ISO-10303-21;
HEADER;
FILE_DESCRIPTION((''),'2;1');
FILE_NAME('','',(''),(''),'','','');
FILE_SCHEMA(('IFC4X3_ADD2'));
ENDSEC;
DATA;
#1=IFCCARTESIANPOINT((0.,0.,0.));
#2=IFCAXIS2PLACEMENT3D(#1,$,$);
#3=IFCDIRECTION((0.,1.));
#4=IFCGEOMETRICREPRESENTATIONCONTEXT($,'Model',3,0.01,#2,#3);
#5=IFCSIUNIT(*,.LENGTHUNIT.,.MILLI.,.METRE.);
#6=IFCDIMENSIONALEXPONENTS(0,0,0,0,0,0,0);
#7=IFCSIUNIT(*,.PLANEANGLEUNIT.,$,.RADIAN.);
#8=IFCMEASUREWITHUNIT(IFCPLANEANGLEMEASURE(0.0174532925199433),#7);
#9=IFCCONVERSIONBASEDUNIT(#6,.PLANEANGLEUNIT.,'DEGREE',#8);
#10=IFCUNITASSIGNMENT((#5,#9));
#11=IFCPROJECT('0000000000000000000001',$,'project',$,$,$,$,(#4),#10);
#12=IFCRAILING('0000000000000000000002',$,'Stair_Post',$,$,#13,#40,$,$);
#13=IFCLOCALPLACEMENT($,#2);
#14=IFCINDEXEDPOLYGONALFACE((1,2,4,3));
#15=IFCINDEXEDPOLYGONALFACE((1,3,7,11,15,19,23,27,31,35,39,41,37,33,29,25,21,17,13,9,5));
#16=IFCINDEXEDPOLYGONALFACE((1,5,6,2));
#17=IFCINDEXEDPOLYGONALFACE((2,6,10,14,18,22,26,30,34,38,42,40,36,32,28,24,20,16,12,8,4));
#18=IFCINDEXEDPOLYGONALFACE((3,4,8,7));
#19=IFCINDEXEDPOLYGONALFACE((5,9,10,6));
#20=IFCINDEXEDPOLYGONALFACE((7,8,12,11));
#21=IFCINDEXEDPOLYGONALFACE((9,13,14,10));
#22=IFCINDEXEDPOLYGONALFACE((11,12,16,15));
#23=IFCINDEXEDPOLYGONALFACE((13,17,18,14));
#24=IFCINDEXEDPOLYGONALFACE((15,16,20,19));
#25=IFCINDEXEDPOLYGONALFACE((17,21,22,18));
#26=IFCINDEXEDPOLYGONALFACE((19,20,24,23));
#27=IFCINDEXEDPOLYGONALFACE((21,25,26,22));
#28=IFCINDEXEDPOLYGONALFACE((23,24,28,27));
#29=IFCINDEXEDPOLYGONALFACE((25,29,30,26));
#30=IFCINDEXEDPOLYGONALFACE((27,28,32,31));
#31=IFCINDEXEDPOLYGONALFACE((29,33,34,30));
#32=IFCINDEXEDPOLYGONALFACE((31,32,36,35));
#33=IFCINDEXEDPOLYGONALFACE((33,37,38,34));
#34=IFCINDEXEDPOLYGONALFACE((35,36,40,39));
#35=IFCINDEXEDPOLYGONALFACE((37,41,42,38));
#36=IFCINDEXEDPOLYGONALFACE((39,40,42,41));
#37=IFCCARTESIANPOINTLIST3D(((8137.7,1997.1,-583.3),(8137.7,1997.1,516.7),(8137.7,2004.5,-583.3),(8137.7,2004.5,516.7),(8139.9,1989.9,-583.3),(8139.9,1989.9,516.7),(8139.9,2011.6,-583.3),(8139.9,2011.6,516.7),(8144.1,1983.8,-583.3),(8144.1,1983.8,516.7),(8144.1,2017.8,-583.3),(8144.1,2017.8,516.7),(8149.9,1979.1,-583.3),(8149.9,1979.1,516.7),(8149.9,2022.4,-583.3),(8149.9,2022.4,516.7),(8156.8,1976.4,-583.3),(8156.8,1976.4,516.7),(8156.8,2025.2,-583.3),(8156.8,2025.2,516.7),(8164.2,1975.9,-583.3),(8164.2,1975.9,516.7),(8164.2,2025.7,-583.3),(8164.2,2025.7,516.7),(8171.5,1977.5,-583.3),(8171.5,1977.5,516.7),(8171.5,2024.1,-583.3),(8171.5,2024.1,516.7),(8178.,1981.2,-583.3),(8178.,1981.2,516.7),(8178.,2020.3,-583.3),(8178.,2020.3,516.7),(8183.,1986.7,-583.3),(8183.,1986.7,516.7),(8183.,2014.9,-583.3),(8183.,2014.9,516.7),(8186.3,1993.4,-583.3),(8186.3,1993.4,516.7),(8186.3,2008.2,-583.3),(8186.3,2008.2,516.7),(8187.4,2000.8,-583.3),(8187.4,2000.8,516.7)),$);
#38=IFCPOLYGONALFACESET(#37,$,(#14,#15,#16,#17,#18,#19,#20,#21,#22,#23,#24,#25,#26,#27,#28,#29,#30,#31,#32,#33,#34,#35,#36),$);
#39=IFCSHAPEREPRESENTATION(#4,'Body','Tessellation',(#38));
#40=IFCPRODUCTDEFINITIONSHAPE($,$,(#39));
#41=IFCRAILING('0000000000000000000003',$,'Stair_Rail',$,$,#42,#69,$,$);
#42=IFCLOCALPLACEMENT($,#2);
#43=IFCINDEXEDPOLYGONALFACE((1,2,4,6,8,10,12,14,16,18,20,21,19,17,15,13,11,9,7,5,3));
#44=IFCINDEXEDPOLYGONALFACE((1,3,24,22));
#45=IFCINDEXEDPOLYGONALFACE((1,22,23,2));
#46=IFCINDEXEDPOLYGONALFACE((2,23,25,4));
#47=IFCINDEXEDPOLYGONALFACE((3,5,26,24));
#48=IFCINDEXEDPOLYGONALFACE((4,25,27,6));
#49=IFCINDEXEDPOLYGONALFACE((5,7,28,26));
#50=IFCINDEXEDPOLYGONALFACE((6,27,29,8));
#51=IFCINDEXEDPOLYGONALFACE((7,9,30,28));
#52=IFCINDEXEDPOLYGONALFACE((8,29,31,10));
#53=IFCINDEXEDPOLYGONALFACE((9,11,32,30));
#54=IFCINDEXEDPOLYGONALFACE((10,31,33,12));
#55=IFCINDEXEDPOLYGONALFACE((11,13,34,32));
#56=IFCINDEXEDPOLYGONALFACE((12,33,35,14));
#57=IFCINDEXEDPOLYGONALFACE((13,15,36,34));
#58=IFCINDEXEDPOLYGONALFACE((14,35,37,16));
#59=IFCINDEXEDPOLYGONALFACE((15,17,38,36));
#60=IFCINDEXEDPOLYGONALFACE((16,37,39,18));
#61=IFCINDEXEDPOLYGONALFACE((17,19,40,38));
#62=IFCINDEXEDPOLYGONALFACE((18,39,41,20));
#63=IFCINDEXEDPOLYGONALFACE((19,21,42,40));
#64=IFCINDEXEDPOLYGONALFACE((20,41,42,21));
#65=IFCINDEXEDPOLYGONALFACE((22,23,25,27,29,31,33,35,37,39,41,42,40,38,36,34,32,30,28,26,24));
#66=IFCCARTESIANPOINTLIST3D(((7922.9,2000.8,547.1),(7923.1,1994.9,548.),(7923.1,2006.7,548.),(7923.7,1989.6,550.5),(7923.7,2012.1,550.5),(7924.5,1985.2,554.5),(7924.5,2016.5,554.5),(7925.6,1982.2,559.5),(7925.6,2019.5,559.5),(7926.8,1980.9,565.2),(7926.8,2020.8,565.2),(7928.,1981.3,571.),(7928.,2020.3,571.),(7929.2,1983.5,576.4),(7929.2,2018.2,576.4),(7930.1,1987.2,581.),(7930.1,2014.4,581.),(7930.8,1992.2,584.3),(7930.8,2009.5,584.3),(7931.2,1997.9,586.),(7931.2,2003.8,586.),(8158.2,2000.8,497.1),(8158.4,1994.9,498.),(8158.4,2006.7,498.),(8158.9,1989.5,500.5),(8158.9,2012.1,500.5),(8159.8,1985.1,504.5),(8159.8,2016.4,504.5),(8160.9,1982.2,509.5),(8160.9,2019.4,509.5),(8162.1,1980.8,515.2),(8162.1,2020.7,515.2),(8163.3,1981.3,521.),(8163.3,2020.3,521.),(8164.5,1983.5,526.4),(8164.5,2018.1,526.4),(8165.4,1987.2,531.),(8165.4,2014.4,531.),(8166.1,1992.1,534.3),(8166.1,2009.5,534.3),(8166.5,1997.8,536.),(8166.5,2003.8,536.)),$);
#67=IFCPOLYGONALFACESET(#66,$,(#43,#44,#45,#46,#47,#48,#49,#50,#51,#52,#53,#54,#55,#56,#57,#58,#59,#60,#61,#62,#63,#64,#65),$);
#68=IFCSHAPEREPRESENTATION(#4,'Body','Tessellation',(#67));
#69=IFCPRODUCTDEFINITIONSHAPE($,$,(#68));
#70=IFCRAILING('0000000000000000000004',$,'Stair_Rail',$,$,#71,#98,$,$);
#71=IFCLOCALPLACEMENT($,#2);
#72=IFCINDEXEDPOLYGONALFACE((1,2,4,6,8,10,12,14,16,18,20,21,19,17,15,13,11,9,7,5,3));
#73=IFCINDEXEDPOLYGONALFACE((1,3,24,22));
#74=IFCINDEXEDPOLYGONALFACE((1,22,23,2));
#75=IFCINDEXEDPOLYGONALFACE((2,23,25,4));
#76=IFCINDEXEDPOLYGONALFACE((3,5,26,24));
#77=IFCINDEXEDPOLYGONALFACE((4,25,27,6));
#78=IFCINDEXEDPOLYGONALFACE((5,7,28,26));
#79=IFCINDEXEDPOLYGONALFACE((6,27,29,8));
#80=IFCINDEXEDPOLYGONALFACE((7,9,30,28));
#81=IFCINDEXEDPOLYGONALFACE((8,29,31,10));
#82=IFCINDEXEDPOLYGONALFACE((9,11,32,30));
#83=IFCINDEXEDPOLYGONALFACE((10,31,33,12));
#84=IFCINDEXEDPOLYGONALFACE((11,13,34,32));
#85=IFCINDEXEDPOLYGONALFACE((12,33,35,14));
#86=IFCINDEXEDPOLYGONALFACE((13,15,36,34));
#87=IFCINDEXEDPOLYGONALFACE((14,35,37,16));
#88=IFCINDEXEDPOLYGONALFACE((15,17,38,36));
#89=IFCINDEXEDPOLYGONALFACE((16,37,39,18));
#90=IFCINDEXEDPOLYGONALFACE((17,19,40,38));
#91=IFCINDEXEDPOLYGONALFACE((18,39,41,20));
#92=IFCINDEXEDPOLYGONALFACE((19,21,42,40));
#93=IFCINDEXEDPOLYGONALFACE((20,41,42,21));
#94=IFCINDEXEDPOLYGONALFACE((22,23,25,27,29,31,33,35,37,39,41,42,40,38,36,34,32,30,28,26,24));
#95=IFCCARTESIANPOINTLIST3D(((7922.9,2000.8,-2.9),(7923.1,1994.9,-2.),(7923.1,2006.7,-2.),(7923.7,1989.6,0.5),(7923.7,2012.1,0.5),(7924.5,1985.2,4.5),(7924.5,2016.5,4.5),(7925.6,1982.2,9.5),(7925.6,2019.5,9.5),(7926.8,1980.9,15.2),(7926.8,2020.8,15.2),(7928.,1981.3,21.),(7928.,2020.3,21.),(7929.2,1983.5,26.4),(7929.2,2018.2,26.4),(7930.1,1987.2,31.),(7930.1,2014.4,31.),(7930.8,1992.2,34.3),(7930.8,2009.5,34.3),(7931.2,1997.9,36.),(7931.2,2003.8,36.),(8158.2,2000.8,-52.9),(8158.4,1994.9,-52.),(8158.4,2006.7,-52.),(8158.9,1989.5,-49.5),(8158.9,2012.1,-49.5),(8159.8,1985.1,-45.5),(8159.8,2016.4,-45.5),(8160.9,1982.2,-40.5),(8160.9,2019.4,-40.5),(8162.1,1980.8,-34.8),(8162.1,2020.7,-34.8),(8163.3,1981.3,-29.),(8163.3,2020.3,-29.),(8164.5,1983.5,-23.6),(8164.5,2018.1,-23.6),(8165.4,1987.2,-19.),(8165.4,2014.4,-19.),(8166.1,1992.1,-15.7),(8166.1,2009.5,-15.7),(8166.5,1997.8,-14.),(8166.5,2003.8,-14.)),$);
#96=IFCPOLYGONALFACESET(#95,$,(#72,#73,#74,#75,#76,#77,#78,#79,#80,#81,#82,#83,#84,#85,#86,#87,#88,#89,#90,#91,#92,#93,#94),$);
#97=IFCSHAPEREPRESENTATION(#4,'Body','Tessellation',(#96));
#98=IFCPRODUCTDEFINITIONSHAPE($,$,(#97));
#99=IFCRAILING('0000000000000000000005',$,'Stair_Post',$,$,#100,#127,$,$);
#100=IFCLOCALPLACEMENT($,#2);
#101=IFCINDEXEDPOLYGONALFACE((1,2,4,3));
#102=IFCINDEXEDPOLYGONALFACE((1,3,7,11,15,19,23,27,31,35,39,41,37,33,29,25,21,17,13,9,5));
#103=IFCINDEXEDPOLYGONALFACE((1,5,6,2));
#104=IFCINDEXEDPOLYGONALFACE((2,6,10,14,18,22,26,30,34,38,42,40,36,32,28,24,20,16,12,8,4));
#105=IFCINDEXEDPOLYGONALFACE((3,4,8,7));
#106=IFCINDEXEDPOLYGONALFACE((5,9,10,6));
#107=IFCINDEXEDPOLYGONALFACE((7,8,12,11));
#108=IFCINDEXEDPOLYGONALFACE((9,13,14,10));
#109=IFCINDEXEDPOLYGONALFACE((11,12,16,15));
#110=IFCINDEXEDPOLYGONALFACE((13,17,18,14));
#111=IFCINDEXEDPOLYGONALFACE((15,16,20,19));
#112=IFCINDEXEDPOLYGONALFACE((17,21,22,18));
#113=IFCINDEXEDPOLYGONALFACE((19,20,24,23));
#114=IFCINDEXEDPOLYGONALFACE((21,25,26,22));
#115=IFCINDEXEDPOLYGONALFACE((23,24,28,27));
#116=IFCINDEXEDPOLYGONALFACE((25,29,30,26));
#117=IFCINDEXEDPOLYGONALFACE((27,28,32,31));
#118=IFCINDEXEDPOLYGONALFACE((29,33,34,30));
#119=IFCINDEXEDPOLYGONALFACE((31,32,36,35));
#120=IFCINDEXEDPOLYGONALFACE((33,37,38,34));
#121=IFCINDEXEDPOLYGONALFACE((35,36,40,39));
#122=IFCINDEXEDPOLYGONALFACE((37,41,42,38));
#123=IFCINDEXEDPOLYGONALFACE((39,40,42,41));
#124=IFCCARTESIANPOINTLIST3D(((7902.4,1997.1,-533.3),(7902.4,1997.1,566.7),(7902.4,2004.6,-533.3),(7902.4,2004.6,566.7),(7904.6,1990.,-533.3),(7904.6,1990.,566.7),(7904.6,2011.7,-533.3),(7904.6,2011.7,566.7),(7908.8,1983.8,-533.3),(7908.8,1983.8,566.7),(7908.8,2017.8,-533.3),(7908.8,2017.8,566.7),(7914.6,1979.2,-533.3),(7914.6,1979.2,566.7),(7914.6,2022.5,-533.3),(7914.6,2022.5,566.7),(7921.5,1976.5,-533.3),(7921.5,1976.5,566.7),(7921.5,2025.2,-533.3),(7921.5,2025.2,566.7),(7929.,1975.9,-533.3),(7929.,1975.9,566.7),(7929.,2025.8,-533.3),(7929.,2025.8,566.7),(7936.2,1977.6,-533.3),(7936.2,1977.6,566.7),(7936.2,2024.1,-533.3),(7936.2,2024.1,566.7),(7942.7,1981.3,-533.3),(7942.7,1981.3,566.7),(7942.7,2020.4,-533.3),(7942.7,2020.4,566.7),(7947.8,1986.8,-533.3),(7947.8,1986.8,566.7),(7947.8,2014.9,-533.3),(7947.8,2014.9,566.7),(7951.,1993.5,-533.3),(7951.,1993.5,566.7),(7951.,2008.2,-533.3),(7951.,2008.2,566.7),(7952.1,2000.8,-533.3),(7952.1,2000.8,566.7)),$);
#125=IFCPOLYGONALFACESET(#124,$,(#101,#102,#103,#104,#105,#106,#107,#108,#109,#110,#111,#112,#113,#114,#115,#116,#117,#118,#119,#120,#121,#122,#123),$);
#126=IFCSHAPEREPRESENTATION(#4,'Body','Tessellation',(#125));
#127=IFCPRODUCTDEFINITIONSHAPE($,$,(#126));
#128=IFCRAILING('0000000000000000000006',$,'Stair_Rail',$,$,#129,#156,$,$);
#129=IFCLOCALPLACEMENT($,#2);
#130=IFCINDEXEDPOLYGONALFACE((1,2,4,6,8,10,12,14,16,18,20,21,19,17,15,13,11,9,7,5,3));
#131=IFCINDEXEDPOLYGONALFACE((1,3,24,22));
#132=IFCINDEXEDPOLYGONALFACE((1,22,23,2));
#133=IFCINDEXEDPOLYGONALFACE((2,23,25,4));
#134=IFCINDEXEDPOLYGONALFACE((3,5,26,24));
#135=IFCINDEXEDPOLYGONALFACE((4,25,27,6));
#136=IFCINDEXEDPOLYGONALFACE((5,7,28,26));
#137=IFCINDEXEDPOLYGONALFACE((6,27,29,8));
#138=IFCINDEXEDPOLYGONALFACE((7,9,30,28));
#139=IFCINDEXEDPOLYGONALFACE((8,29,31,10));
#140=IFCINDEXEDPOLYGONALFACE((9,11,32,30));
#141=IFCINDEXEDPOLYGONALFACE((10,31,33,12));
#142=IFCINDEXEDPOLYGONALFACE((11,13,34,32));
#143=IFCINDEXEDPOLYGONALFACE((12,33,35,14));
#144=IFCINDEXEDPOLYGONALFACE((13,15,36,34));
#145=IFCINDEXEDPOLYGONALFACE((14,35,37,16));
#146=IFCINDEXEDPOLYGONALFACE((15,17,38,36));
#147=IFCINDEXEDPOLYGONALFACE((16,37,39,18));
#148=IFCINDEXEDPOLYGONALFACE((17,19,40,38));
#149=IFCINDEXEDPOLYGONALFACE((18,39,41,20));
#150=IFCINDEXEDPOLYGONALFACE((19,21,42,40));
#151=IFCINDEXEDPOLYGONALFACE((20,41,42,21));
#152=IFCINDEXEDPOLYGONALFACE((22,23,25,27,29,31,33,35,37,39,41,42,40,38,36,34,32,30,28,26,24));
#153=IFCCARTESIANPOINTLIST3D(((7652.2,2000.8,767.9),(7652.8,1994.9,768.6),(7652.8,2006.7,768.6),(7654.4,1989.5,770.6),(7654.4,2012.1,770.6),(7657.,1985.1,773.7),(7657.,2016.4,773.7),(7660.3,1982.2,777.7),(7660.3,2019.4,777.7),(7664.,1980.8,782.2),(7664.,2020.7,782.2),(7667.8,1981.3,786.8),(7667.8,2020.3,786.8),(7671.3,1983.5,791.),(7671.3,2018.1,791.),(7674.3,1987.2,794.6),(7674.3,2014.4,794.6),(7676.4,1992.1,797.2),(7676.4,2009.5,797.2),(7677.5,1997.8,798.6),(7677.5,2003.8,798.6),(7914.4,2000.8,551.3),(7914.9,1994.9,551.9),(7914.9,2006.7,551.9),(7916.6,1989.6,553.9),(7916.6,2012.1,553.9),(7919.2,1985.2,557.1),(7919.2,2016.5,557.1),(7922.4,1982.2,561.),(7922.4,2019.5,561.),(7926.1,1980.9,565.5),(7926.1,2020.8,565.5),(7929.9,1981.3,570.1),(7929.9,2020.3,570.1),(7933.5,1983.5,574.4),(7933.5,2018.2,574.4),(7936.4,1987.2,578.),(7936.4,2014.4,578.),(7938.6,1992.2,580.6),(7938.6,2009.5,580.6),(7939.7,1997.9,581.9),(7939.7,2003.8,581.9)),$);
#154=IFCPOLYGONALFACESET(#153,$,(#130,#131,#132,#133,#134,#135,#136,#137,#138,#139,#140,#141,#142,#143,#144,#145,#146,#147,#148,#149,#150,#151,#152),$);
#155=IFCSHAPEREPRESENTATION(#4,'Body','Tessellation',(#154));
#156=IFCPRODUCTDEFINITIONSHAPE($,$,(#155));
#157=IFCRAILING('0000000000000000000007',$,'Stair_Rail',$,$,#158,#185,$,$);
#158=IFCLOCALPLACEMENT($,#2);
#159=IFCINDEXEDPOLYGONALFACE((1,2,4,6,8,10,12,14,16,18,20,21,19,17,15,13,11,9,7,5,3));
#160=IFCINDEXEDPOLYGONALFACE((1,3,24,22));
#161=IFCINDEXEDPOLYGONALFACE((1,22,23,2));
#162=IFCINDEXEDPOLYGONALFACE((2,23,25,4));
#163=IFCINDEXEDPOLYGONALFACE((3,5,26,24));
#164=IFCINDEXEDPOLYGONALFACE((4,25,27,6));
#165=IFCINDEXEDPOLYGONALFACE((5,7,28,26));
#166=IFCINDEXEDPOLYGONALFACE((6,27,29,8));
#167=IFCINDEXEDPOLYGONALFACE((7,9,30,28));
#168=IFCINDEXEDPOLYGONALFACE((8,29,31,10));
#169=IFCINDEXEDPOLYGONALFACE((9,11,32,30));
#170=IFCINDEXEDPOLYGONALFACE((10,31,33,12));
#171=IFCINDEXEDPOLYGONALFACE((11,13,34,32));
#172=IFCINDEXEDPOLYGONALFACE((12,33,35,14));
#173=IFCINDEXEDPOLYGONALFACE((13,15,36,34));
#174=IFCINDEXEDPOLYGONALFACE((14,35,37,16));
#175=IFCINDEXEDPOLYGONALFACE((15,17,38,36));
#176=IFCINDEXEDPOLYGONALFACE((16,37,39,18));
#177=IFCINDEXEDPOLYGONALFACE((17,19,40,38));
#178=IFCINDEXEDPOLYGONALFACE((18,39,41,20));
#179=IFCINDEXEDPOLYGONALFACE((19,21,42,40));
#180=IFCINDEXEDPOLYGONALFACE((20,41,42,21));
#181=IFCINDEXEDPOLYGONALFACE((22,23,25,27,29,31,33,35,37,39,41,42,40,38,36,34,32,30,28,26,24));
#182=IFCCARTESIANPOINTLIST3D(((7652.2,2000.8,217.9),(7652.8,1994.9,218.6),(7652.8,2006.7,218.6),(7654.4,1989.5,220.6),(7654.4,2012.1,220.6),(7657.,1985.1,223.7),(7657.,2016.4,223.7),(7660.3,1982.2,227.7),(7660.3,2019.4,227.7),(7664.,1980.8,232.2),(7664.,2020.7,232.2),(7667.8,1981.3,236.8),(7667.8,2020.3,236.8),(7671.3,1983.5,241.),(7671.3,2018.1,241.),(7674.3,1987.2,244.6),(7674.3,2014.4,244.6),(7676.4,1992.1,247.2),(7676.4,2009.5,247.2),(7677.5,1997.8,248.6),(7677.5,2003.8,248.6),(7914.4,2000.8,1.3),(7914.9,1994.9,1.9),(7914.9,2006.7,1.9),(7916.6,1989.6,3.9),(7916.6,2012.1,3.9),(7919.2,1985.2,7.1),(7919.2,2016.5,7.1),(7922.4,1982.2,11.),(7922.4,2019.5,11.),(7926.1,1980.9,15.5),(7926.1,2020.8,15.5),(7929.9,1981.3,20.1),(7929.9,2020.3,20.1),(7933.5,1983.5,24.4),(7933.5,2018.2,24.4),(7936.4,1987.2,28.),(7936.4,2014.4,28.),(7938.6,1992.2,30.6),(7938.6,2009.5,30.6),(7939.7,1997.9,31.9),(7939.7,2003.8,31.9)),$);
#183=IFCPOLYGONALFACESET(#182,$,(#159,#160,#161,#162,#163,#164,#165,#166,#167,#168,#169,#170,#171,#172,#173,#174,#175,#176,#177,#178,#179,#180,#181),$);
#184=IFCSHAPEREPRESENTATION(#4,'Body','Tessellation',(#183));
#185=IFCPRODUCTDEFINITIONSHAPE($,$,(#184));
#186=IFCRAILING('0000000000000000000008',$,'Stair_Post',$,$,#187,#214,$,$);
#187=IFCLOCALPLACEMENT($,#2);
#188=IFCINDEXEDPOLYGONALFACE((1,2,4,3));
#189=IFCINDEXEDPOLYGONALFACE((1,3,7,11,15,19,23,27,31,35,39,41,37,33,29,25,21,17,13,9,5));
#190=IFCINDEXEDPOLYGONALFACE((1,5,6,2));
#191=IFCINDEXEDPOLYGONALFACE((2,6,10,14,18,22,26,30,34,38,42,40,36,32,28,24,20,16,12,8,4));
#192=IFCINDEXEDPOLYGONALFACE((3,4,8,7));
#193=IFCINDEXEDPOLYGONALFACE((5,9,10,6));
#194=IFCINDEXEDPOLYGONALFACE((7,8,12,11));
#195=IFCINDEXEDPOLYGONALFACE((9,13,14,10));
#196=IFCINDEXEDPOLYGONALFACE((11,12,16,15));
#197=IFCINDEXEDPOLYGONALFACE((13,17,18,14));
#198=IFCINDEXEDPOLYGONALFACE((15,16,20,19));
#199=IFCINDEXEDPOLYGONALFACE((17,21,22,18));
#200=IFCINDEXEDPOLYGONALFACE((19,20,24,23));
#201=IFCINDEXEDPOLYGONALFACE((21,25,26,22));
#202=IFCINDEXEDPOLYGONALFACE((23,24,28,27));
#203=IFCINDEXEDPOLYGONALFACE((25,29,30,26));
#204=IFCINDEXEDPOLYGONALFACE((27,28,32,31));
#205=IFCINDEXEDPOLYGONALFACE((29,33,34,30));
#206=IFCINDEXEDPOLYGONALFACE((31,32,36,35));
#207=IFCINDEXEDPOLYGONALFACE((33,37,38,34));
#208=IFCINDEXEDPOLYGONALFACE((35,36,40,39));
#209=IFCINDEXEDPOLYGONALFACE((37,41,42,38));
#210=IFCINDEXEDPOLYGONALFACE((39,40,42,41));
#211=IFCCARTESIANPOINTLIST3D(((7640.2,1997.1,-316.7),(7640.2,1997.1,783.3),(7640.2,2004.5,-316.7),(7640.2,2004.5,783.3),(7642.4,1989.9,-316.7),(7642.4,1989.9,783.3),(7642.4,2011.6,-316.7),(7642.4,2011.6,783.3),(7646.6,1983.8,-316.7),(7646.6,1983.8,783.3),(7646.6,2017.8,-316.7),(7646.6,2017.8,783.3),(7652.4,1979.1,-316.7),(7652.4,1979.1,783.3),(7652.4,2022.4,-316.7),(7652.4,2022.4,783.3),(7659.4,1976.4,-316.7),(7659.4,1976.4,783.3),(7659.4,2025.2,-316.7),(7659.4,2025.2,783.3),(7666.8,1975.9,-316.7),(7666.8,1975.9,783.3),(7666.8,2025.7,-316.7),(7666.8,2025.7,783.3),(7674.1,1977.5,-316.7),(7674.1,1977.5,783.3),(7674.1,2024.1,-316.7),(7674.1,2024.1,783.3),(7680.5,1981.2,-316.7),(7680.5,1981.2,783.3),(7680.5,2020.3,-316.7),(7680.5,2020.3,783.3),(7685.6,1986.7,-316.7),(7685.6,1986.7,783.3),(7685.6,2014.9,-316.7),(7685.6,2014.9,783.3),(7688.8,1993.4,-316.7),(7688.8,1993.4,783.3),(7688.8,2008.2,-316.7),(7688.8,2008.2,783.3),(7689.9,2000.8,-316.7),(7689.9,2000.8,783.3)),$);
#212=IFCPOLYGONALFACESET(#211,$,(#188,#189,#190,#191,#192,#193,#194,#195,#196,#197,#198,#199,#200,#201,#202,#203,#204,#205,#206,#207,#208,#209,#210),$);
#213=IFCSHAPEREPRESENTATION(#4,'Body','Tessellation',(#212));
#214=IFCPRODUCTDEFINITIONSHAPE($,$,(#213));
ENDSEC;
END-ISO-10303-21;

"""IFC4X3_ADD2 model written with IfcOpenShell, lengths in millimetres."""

from ifc_helpers import new_model, entity, si_unit, converted_unit, direction, frame, origin, context, project, circle, extrude, element, save


model = new_model("IFC4X3_ADD2")

# Units and contexts
model_context = context("Model", 3, precision=0.01, world=origin(), true_north=direction((0.0, 1.0)))
ifc_project = project(units=[si_unit("LENGTHUNIT", "METRE", prefix="MILLI"), converted_unit("PLANEANGLEUNIT", "DEGREE", entity("IfcPlaneAngleMeasure", 0.0174532925199433), si_unit("PLANEANGLEUNIT", "RADIAN"), dimensions=[0, 0, 0, 0, 0, 0, 0])], contexts=[model_context])

# Railings
element("IfcRailing", 1, Name="Stair_Post", context=model_context, shape_type="SweptSolid", body=[
    extrude(circle(Radius=25.0), frame((8162.4, 2000.8, -583.3)), (0.0, 0.0, 1.0), 1100.0),
])
element("IfcRailing", 2, Name="Stair_Rail", context=model_context, shape_type="SweptSolid", body=[
    entity("IfcSweptDiskSolid", entity("IfcPolyline", [entity("IfcCartesianPoint", [8162.4, 2000.8, 516.7]), entity("IfcCartesianPoint", [7927.1, 2000.8, 566.7])]), 20.0),
])
element("IfcRailing", 3, Name="Stair_Rail", context=model_context, shape_type="SweptSolid", body=[
    entity("IfcSweptDiskSolid", entity("IfcPolyline", [entity("IfcCartesianPoint", [8162.4, 2000.8, -33.3]), entity("IfcCartesianPoint", [7927.1, 2000.8, 16.7])]), 20.0),
])
element("IfcRailing", 4, Name="Stair_Post", context=model_context, shape_type="SweptSolid", body=[
    extrude(circle(Radius=25.0), frame((7927.1, 2000.8, -533.3)), (0.0, 0.0, 1.0), 1100.0),
])
element("IfcRailing", 5, Name="Stair_Rail", context=model_context, shape_type="SweptSolid", body=[
    entity("IfcSweptDiskSolid", entity("IfcPolyline", [entity("IfcCartesianPoint", [7927.1, 2000.8, 566.7]), entity("IfcCartesianPoint", [7664.9, 2000.8, 783.3])]), 20.0),
])
element("IfcRailing", 6, Name="Stair_Rail", context=model_context, shape_type="SweptSolid", body=[
    entity("IfcSweptDiskSolid", entity("IfcPolyline", [entity("IfcCartesianPoint", [7927.1, 2000.8, 16.7]), entity("IfcCartesianPoint", [7664.9, 2000.8, 233.3])]), 20.0),
])
element("IfcRailing", 7, Name="Stair_Post", context=model_context, shape_type="SweptSolid", body=[
    extrude(circle(Radius=25.0), frame((7664.9, 2000.8, -316.7)), (0.0, 0.0, 1.0), 1100.0),
])

save(model, "model.ifc")
